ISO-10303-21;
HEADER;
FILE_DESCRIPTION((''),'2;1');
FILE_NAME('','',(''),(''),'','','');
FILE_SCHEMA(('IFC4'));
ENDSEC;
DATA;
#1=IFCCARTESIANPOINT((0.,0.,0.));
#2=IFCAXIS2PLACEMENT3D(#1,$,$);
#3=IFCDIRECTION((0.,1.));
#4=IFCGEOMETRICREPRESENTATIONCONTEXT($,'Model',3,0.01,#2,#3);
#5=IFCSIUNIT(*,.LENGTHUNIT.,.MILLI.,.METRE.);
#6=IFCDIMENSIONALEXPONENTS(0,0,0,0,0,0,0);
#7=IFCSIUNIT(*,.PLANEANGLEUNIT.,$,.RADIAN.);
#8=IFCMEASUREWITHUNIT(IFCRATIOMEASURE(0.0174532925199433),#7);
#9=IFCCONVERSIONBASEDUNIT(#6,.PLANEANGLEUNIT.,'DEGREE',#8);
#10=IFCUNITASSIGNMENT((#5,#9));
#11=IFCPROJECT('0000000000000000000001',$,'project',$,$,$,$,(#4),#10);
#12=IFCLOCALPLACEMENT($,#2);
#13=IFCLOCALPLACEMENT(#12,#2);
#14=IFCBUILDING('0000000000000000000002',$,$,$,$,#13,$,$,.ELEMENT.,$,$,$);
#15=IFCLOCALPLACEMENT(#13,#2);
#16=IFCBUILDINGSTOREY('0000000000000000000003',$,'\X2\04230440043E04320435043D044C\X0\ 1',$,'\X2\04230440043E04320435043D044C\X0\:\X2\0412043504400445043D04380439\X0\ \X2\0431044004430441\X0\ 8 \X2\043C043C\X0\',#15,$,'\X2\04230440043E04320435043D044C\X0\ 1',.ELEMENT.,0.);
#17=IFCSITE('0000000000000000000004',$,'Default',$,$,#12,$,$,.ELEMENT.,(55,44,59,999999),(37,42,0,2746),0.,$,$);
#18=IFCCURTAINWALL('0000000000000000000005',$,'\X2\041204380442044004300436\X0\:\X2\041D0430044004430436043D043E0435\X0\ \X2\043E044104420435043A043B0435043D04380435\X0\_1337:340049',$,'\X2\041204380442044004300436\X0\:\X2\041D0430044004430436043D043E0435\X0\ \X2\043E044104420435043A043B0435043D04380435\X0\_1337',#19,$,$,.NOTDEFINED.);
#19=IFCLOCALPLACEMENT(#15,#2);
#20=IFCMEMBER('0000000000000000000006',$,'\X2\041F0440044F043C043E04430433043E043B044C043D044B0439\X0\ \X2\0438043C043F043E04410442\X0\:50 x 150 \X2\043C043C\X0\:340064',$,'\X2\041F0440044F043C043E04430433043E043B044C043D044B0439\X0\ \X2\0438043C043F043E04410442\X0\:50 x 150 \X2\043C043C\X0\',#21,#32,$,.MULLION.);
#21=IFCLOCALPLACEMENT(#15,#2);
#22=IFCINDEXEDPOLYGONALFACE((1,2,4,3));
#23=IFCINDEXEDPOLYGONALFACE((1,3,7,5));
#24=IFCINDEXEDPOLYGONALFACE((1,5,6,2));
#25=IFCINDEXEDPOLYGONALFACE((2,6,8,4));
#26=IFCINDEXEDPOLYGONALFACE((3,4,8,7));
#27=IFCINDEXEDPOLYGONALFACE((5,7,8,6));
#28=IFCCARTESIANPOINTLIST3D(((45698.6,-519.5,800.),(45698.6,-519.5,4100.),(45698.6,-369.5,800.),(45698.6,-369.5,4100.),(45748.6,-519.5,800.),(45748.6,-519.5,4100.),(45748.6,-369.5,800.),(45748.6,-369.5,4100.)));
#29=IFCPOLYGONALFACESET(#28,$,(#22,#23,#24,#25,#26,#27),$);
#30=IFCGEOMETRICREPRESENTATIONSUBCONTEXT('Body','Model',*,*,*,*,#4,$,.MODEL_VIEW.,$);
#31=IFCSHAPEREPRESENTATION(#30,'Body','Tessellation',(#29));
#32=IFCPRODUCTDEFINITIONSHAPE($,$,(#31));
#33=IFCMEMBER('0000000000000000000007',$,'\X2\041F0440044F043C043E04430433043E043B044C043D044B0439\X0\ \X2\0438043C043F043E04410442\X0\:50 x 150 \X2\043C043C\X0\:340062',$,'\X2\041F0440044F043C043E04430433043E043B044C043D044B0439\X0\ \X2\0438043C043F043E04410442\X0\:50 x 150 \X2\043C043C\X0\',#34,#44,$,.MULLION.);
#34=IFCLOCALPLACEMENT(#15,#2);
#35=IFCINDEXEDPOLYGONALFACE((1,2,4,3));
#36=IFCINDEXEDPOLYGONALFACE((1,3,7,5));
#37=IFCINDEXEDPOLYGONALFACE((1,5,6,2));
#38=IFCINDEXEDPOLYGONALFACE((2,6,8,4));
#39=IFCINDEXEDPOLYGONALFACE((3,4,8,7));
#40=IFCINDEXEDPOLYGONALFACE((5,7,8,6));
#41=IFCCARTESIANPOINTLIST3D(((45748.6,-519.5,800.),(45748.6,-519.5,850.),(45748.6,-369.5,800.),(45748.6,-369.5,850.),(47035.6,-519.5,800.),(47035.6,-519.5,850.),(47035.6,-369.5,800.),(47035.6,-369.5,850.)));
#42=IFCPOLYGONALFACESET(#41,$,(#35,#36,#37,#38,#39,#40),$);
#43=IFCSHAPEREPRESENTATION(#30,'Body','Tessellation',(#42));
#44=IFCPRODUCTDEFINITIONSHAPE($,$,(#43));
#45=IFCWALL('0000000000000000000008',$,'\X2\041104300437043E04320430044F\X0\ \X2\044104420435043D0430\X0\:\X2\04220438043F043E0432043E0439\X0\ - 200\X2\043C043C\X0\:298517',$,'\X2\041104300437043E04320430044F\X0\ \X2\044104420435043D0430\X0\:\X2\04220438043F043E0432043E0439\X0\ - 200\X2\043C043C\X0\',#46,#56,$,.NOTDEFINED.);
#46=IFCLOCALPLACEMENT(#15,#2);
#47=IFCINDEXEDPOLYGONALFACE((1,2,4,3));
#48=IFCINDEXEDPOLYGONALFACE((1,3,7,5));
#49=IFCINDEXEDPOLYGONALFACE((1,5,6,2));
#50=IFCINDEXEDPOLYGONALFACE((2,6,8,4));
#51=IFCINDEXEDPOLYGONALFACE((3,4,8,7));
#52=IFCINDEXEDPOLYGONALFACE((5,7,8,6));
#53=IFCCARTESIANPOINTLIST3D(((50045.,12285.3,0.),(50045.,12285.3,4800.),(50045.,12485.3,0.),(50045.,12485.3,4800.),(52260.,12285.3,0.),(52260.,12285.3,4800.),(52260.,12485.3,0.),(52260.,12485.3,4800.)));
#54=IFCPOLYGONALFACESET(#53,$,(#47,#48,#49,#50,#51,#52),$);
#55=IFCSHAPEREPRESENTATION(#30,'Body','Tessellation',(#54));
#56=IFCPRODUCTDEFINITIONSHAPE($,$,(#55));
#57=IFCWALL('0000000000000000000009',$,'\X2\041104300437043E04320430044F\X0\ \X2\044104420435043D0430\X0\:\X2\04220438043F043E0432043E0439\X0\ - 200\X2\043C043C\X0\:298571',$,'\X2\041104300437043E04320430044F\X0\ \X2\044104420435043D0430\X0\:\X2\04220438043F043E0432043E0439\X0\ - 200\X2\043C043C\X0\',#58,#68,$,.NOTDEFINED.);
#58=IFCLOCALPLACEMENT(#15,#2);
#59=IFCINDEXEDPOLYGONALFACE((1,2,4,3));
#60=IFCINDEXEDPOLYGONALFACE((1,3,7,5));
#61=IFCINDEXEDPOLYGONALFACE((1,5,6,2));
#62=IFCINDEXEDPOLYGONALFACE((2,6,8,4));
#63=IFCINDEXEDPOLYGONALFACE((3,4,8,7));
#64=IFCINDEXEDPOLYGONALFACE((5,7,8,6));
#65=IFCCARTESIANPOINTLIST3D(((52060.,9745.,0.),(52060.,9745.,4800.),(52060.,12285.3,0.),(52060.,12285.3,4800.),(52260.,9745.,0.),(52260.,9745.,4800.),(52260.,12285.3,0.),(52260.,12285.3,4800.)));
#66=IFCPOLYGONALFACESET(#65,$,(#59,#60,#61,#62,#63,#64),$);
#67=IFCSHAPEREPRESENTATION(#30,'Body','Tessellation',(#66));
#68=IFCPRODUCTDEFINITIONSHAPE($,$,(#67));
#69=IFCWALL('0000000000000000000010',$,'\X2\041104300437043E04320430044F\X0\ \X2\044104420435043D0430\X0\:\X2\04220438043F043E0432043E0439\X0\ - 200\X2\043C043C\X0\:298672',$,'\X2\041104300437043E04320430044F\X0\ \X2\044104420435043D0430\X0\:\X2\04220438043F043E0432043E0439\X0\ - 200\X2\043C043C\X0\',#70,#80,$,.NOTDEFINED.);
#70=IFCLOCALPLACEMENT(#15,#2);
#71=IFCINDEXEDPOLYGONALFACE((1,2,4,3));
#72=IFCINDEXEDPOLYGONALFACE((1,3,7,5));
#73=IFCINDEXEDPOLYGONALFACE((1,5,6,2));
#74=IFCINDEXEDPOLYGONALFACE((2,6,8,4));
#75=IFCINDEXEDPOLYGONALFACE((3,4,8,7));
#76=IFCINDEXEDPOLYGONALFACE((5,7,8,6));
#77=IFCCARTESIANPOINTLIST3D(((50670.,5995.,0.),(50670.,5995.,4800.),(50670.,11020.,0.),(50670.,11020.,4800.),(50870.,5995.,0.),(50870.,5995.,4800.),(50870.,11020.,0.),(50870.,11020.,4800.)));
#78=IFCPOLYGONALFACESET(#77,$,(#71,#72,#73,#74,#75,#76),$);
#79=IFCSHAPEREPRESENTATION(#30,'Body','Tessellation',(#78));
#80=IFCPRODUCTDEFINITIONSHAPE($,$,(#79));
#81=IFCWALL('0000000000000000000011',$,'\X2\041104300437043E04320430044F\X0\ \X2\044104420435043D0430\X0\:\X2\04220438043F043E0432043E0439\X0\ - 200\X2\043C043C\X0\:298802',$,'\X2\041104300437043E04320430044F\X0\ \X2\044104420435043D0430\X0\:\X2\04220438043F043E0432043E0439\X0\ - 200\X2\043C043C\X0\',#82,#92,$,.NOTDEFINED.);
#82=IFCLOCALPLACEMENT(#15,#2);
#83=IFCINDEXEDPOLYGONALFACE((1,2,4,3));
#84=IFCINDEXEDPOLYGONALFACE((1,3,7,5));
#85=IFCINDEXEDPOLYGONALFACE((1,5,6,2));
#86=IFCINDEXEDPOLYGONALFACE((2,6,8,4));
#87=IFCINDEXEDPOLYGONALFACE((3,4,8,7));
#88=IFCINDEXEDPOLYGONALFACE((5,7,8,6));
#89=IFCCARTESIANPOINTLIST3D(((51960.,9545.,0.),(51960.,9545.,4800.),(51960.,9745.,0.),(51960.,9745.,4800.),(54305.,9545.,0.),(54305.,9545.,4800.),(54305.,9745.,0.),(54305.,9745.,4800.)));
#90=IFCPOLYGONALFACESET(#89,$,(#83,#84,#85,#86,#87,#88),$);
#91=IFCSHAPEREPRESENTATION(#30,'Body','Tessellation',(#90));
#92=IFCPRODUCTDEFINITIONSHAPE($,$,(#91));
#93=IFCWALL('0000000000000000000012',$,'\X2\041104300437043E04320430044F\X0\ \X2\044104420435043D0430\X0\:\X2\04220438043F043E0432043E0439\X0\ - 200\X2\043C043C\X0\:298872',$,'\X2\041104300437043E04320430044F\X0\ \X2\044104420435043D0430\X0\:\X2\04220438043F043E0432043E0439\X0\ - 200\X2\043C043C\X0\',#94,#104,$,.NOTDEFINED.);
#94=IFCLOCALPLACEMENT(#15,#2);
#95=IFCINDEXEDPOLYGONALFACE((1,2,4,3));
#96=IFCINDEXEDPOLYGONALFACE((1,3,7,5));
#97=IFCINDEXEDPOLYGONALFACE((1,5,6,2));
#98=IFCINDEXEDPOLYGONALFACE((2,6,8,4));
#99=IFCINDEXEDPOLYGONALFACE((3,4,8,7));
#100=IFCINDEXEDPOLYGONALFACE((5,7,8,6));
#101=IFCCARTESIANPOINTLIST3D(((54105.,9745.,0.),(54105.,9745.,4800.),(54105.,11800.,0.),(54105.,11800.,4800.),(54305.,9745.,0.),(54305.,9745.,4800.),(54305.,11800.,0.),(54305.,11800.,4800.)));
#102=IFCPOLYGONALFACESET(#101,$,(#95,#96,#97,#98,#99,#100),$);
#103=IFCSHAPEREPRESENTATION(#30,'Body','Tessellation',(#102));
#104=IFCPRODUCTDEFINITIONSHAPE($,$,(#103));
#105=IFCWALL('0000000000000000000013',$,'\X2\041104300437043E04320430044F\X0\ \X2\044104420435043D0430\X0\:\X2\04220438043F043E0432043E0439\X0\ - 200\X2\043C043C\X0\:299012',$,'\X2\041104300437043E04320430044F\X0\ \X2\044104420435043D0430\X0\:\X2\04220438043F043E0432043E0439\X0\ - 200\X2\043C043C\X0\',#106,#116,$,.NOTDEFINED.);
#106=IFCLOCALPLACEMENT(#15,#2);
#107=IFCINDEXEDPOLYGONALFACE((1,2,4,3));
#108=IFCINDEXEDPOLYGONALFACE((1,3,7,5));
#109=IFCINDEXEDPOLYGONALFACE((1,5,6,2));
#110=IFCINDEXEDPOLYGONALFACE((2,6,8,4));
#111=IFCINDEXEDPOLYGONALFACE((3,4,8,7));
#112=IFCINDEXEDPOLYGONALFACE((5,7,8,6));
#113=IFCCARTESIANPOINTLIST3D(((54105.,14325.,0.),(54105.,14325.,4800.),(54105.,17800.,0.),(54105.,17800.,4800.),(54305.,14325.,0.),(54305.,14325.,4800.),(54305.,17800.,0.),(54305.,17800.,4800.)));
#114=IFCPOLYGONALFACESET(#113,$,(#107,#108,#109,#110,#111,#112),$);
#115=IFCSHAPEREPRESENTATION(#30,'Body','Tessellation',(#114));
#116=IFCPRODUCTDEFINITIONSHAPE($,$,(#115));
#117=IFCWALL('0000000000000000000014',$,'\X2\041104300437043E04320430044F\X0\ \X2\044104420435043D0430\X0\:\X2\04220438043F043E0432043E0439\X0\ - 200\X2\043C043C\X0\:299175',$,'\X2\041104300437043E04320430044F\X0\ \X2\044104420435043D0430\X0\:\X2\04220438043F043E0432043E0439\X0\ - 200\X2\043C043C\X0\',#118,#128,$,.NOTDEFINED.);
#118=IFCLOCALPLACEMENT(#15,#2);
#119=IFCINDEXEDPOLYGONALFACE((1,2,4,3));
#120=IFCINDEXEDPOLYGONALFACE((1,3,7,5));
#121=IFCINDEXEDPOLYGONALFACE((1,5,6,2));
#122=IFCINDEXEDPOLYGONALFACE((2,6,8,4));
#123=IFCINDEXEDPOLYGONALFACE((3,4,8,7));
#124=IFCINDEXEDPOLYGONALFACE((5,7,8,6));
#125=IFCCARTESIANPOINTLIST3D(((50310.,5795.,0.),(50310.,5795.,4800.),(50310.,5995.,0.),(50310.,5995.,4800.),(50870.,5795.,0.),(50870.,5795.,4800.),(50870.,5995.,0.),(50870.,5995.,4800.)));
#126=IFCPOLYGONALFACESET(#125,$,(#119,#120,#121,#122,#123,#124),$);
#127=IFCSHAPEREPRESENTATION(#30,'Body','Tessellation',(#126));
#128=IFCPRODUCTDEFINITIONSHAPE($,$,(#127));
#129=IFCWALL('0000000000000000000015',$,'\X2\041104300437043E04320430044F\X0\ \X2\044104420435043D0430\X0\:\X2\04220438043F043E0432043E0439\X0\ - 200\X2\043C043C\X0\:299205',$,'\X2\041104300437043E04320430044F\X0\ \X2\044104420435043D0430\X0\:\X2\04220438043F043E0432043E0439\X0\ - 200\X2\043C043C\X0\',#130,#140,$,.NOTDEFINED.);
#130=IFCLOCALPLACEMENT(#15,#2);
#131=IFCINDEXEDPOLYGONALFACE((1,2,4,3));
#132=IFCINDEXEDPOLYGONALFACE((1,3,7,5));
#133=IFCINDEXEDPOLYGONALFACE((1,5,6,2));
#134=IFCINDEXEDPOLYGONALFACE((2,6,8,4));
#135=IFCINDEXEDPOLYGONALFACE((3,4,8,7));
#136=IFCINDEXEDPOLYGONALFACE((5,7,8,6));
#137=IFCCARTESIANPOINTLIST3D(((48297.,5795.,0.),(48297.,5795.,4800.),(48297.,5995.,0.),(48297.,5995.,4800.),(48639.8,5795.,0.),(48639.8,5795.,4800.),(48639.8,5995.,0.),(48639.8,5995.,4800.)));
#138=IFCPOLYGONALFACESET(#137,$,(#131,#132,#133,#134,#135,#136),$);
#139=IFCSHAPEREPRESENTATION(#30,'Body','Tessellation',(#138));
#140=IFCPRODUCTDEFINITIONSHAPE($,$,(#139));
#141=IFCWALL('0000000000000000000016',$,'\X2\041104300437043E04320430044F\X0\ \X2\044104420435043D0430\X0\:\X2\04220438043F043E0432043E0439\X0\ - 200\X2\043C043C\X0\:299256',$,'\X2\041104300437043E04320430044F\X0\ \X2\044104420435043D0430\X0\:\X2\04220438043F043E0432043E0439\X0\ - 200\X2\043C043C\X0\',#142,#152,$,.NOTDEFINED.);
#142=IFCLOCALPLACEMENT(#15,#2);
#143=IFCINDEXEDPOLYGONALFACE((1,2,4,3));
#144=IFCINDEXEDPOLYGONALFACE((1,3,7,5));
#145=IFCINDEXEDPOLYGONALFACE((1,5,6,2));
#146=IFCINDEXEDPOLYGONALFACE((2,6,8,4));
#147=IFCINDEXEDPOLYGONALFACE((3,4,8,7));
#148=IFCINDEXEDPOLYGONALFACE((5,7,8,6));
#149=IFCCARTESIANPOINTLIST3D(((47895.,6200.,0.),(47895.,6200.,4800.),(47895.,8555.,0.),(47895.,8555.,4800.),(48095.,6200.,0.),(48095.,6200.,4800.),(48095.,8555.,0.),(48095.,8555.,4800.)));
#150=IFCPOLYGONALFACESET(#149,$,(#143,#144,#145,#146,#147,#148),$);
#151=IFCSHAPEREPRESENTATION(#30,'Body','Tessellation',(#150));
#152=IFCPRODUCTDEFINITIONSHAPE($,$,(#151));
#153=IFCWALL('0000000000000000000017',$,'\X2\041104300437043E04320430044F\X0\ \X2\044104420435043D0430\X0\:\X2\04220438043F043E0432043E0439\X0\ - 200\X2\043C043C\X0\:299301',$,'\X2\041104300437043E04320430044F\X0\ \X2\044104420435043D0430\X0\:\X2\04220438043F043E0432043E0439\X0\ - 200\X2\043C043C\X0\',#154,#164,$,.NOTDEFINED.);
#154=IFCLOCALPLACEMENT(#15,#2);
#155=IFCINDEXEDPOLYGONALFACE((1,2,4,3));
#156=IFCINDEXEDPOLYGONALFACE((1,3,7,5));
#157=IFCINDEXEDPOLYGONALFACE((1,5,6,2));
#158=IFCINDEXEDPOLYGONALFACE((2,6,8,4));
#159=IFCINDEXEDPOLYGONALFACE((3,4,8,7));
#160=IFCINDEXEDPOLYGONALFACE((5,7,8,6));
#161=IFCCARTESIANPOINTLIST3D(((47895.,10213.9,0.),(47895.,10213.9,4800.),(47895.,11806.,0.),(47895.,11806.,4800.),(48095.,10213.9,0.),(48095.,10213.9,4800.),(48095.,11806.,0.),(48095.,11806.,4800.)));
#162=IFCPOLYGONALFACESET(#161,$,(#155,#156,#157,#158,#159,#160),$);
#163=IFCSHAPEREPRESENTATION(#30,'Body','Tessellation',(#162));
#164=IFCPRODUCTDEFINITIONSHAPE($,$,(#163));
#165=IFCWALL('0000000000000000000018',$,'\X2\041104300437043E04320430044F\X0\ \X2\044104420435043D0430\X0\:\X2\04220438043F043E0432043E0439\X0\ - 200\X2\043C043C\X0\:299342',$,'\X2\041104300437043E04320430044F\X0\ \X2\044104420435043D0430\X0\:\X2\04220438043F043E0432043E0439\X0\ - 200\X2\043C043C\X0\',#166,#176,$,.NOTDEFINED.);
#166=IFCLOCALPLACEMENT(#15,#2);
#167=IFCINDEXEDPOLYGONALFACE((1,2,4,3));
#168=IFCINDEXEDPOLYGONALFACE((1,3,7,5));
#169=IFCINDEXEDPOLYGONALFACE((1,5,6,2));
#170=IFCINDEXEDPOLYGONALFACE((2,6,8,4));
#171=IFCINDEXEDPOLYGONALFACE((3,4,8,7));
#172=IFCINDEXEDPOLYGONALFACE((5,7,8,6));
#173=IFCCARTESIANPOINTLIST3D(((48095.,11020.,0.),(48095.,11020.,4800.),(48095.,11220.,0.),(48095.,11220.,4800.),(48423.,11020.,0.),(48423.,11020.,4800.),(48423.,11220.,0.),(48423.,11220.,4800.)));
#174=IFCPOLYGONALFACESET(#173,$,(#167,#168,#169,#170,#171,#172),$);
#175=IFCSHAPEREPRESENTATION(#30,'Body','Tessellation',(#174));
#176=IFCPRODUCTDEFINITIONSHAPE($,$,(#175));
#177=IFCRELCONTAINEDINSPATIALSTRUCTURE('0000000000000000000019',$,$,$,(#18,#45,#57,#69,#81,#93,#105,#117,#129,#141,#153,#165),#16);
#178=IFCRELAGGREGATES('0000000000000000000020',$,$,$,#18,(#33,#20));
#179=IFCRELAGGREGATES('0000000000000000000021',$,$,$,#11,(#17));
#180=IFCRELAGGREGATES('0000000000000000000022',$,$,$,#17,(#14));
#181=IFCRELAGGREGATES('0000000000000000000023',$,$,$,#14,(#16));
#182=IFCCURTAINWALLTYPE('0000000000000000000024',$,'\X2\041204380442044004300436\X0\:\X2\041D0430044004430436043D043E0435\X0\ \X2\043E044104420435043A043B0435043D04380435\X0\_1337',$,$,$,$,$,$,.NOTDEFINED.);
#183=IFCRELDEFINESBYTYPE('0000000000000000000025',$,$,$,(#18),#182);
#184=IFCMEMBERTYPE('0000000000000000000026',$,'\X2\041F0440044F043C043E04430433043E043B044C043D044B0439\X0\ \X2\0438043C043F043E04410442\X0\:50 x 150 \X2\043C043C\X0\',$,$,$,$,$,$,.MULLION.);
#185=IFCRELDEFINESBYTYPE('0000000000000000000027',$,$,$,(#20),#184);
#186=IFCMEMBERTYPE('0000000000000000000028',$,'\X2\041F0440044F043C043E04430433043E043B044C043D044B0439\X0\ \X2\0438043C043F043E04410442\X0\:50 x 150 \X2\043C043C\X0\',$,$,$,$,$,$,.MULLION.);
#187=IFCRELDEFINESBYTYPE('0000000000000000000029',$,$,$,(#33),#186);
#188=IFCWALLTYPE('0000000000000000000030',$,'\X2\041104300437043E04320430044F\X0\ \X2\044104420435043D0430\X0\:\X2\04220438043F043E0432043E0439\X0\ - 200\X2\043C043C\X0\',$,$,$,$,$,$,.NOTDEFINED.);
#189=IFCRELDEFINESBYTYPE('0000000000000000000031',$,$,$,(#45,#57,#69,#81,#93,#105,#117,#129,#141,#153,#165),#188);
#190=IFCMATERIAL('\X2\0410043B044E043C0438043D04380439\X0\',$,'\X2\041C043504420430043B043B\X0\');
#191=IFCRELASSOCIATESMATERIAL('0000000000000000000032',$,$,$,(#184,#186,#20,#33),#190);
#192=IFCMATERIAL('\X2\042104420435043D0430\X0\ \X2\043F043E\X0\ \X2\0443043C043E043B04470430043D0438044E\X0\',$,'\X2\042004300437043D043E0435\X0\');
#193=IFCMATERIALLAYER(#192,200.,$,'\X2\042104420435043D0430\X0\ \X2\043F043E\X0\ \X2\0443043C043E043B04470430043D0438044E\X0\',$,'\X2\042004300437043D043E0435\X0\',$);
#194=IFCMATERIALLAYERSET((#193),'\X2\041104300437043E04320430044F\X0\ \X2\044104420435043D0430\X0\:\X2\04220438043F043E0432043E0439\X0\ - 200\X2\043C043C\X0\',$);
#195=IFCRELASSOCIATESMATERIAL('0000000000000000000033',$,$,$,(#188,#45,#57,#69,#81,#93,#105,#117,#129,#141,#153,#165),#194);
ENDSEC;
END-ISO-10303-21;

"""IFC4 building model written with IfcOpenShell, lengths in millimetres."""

from ifc_helpers import new_model, entity, si_unit, converted_unit, direction, frame, frame_2d, origin, origin_2d_with_axis, place, context, subcontext, project, spatial, rectangle, extrude, source, transform, mapped, material, layer, layer_set, layer_usage, material_profile, profile_set, profile_usage, type_object, type_shapes, element, aggregate, save


model = new_model("IFC4")

# Units and contexts
model_context = context("Model", 3, precision=0.01, world=origin(), true_north=direction((0.0, 1.0)))
body_context = subcontext(model_context, "Body", "Model", "MODEL_VIEW")
ifc_project = project(units=[si_unit("LENGTHUNIT", "METRE", prefix="MILLI"), converted_unit("PLANEANGLEUNIT", "DEGREE", entity("IfcRatioMeasure", 0.0174532925199433), si_unit("PLANEANGLEUNIT", "RADIAN"), dimensions=[0, 0, 0, 0, 0, 0, 0])], contexts=[model_context])

# Site, building, storey
site_placement = place(None, origin())
site = spatial("IfcSite", under=ifc_project, at=site_placement, Name="Default", CompositionType="ELEMENT", RefLatitude=(55, 44, 59, 999999), RefLongitude=(37, 42, 0, 2746), RefElevation=0.0)
building_placement = place(site_placement, origin())
building = spatial("IfcBuilding", under=site, at=building_placement, CompositionType="ELEMENT")
storey_placement = place(building_placement, origin())
storey = spatial("IfcBuildingStorey", under=building, at=storey_placement, Name="Уровень 1", ObjectType="Уровень:Верхний брус 8 мм", LongName="Уровень 1", CompositionType="ELEMENT", Elevation=0.0)

# Curtain wall, members
curtain_wall_type_1 = type_object("IfcCurtainWallType", Name="Витраж:Наружное остекление_1337", PredefinedType="NOTDEFINED")
curtain_wall_1_placement = place(storey_placement, origin())
curtain_wall_1 = element("IfcCurtainWall", 1, at=curtain_wall_1_placement, inside=storey, type_object=curtain_wall_type_1, Name="Витраж:Наружное остекление_1337:340049", ObjectType="Витраж:Наружное остекление_1337", PredefinedType="NOTDEFINED")
ifc_material_1 = material(Name="Алюминий", Category="Металл")
ifc_material_profile = material_profile(ifc_material_1, rectangle(XDim=150.0, YDim=50.0, at=origin_2d_with_axis()), Name="50 x 150 мм")
ifc_profile_set = profile_set([ifc_material_profile], Name="50 x 150 мм")
ifc_profile_usage_1 = profile_usage(ifc_profile_set)
member_type_1 = type_object("IfcMemberType", Name="Прямоугольный импост:50 x 150 мм", PredefinedType="MULLION", material=ifc_profile_set)
shared_shape_1 = source(origin(), body_context, "Body", "SweptSolid", [
    extrude(rectangle(XDim=150.0, YDim=50.0, at=origin_2d_with_axis()), frame((0.0, 0.0, -3300.0), z_axis=(0.0, 0.0, 1.0), x_axis=(0.0, -1.0, 0.0)), (0.0, 0.0, 1.0), 3300.0),
])
type_shapes(member_type_1, [shared_shape_1])
member_1_placement = place(storey_placement, frame((45723.6, -444.5, 800.0), z_axis=(0.0, 0.0, -1.0), x_axis=(1.0, 0.0, 0.0)))
member_1 = element("IfcMember", 2, at=member_1_placement, type_object=member_type_1, material=ifc_profile_usage_1, Name="Прямоугольный импост:50 x 150 мм:340064", ObjectType="Прямоугольный импост:50 x 150 мм", PredefinedType="MULLION", context=body_context, shape_type="MappedRepresentation", body=[
    mapped(shared_shape_1, transform((0.0, 0.0, 0.0), scale=1.0)),
])
ifc_profile_usage_2 = profile_usage(ifc_profile_set)
member_type_2 = type_object("IfcMemberType", Name="Прямоугольный импост:50 x 150 мм", PredefinedType="MULLION", material=ifc_profile_set)
shared_shape_2 = source(origin(), body_context, "Body", "SweptSolid", [
    extrude(rectangle(XDim=150.0, YDim=50.0, at=origin_2d_with_axis()), frame((-25.0, 0.0, -1287.0), z_axis=(0.0, 0.0, 1.0), x_axis=(0.0, -1.0, 0.0)), (0.0, 0.0, 1.0), 1287.0),
])
type_shapes(member_type_2, [shared_shape_2])
member_2_placement = place(storey_placement, frame((45748.6, -444.5, 800.0), z_axis=(-1.0, 0.0, 0.0), x_axis=(0.0, 0.0, -1.0)))
member_2 = element("IfcMember", 3, at=member_2_placement, type_object=member_type_2, material=ifc_profile_usage_2, Name="Прямоугольный импост:50 x 150 мм:340062", ObjectType="Прямоугольный импост:50 x 150 мм", PredefinedType="MULLION", context=body_context, shape_type="MappedRepresentation", body=[
    mapped(shared_shape_2, transform((0.0, 0.0, 0.0), scale=1.0)),
])

aggregate(curtain_wall_1, [member_2, member_1])

# Walls
ifc_material_2 = material(Name="Стена по умолчанию", Category="Разное")
ifc_layer = layer(ifc_material_2, 200.0, Name="Стена по умолчанию", Category="Разное")
ifc_layer_set = layer_set([ifc_layer], Name="Базовая стена:Типовой - 200мм")
ifc_layer_usage_1 = layer_usage(ifc_layer_set, "AXIS2", "NEGATIVE", 100.0)
wall_type = type_object("IfcWallType", Name="Базовая стена:Типовой - 200мм", PredefinedType="NOTDEFINED", material=ifc_layer_set)
wall_1_placement = place(storey_placement, frame((50045.0, 12385.3, 0.0)))
element("IfcWall", 4, at=wall_1_placement, inside=storey, type_object=wall_type, material=ifc_layer_usage_1, Name="Базовая стена:Типовой - 200мм:298517", ObjectType="Базовая стена:Типовой - 200мм", PredefinedType="NOTDEFINED", context=body_context, shape_type="SweptSolid", body=[
    extrude(rectangle(XDim=2215.0, YDim=200.0, at=frame_2d((1107.5, 0.0), x_axis=(-1.0, 0.0))), origin(), (0.0, 0.0, 1.0), 4800.0),
])
ifc_layer_usage_2 = layer_usage(ifc_layer_set, "AXIS2", "NEGATIVE", 100.0)
wall_2_placement = place(storey_placement, frame((52160.0, 12285.3, 0.0), z_axis=(0.0, 0.0, 1.0), x_axis=(0.0, -1.0, 0.0)))
element("IfcWall", 5, at=wall_2_placement, inside=storey, type_object=wall_type, material=ifc_layer_usage_2, Name="Базовая стена:Типовой - 200мм:298571", ObjectType="Базовая стена:Типовой - 200мм", PredefinedType="NOTDEFINED", context=body_context, shape_type="SweptSolid", body=[
    extrude(rectangle(XDim=2540.3, YDim=200.0, at=frame_2d((1270.1, 0.0), x_axis=(-1.0, 0.0))), origin(), (0.0, 0.0, 1.0), 4800.0),
])

# Wall
ifc_layer_usage_3 = layer_usage(ifc_layer_set, "AXIS2", "NEGATIVE", 100.0)
wall_3_placement = place(storey_placement, frame((50770.0, 11020.0, 0.0), z_axis=(0.0, 0.0, 1.0), x_axis=(0.0, -1.0, 0.0)))
element("IfcWall", 6, at=wall_3_placement, inside=storey, type_object=wall_type, material=ifc_layer_usage_3, Name="Базовая стена:Типовой - 200мм:298672", ObjectType="Базовая стена:Типовой - 200мм", PredefinedType="NOTDEFINED", context=body_context, shape_type="SweptSolid", body=[
    extrude(rectangle(XDim=5025.0, YDim=200.0, at=frame_2d((2512.5, 0.0), x_axis=(-1.0, 0.0))), origin(), (0.0, 0.0, 1.0), 4800.0),
])

# Walls
ifc_layer_usage_4 = layer_usage(ifc_layer_set, "AXIS2", "NEGATIVE", 100.0)
wall_4_placement = place(storey_placement, frame((51960.0, 9645.0, 0.0)))
element("IfcWall", 7, at=wall_4_placement, inside=storey, type_object=wall_type, material=ifc_layer_usage_4, Name="Базовая стена:Типовой - 200мм:298802", ObjectType="Базовая стена:Типовой - 200мм", PredefinedType="NOTDEFINED", context=body_context, shape_type="SweptSolid", body=[
    extrude(rectangle(XDim=2345.0, YDim=200.0, at=frame_2d((1172.5, 0.0), x_axis=(-1.0, 0.0))), origin(), (0.0, 0.0, 1.0), 4800.0),
])
ifc_layer_usage_5 = layer_usage(ifc_layer_set, "AXIS2", "NEGATIVE", 100.0)
wall_5_placement = place(storey_placement, frame((54205.0, 9745.0, 0.0), z_axis=(0.0, 0.0, 1.0), x_axis=(0.0, 1.0, 0.0)))
element("IfcWall", 8, at=wall_5_placement, inside=storey, type_object=wall_type, material=ifc_layer_usage_5, Name="Базовая стена:Типовой - 200мм:298872", ObjectType="Базовая стена:Типовой - 200мм", PredefinedType="NOTDEFINED", context=body_context, shape_type="SweptSolid", body=[
    extrude(rectangle(XDim=2055.0, YDim=200.0, at=frame_2d((1027.5, 0.0), x_axis=(-1.0, 0.0))), origin(), (0.0, 0.0, 1.0), 4800.0),
])

# Walls
ifc_layer_usage_6 = layer_usage(ifc_layer_set, "AXIS2", "NEGATIVE", 100.0)
wall_6_placement = place(storey_placement, frame((54205.0, 14325.0, 0.0), z_axis=(0.0, 0.0, 1.0), x_axis=(0.0, 1.0, 0.0)))
element("IfcWall", 9, at=wall_6_placement, inside=storey, type_object=wall_type, material=ifc_layer_usage_6, Name="Базовая стена:Типовой - 200мм:299012", ObjectType="Базовая стена:Типовой - 200мм", PredefinedType="NOTDEFINED", context=body_context, shape_type="SweptSolid", body=[
    extrude(rectangle(XDim=3475.0, YDim=200.0, at=frame_2d((1737.5, 0.0), x_axis=(-1.0, 0.0))), origin(), (0.0, 0.0, 1.0), 4800.0),
])
ifc_layer_usage_7 = layer_usage(ifc_layer_set, "AXIS2", "NEGATIVE", 100.0)
wall_7_placement = place(storey_placement, frame((50870.0, 5895.0, 0.0), z_axis=(0.0, 0.0, 1.0), x_axis=(-1.0, 0.0, 0.0)))
element("IfcWall", 10, at=wall_7_placement, inside=storey, type_object=wall_type, material=ifc_layer_usage_7, Name="Базовая стена:Типовой - 200мм:299175", ObjectType="Базовая стена:Типовой - 200мм", PredefinedType="NOTDEFINED", context=body_context, shape_type="SweptSolid", body=[
    extrude(rectangle(XDim=560.0, YDim=200.0, at=frame_2d((280.0, 0.0), x_axis=(-1.0, 0.0))), origin(), (0.0, 0.0, 1.0), 4800.0),
])
ifc_layer_usage_8 = layer_usage(ifc_layer_set, "AXIS2", "NEGATIVE", 100.0)
wall_8_placement = place(storey_placement, frame((48639.8, 5895.0, 0.0), z_axis=(0.0, 0.0, 1.0), x_axis=(-1.0, 0.0, 0.0)))
element("IfcWall", 11, at=wall_8_placement, inside=storey, type_object=wall_type, material=ifc_layer_usage_8, Name="Базовая стена:Типовой - 200мм:299205", ObjectType="Базовая стена:Типовой - 200мм", PredefinedType="NOTDEFINED", context=body_context, shape_type="SweptSolid", body=[
    extrude(rectangle(XDim=342.7, YDim=200.0, at=frame_2d((171.4, 0.0), x_axis=(-1.0, 0.0))), origin(), (0.0, 0.0, 1.0), 4800.0),
])
ifc_layer_usage_9 = layer_usage(ifc_layer_set, "AXIS2", "NEGATIVE", 100.0)
wall_9_placement = place(storey_placement, frame((47995.0, 6200.0, 0.0), z_axis=(0.0, 0.0, 1.0), x_axis=(0.0, 1.0, 0.0)))
element("IfcWall", 12, at=wall_9_placement, inside=storey, type_object=wall_type, material=ifc_layer_usage_9, Name="Базовая стена:Типовой - 200мм:299256", ObjectType="Базовая стена:Типовой - 200мм", PredefinedType="NOTDEFINED", context=body_context, shape_type="SweptSolid", body=[
    extrude(rectangle(XDim=2355.0, YDim=200.0, at=frame_2d((1177.5, 0.0), x_axis=(-1.0, 0.0))), origin(), (0.0, 0.0, 1.0), 4800.0),
])
ifc_layer_usage_10 = layer_usage(ifc_layer_set, "AXIS2", "NEGATIVE", 100.0)
wall_10_placement = place(storey_placement, frame((47995.0, 10213.9, 0.0), z_axis=(0.0, 0.0, 1.0), x_axis=(0.0, 1.0, 0.0)))
element("IfcWall", 13, at=wall_10_placement, inside=storey, type_object=wall_type, material=ifc_layer_usage_10, Name="Базовая стена:Типовой - 200мм:299301", ObjectType="Базовая стена:Типовой - 200мм", PredefinedType="NOTDEFINED", context=body_context, shape_type="SweptSolid", body=[
    extrude(rectangle(XDim=1592.1, YDim=200.0, at=frame_2d((796.0, 0.0), x_axis=(-1.0, 0.0))), origin(), (0.0, 0.0, 1.0), 4800.0),
])
ifc_layer_usage_11 = layer_usage(ifc_layer_set, "AXIS2", "NEGATIVE", 100.0)
wall_11_placement = place(storey_placement, frame((48095.0, 11120.0, 0.0)))
element("IfcWall", 14, at=wall_11_placement, inside=storey, type_object=wall_type, material=ifc_layer_usage_11, Name="Базовая стена:Типовой - 200мм:299342", ObjectType="Базовая стена:Типовой - 200мм", PredefinedType="NOTDEFINED", context=body_context, shape_type="SweptSolid", body=[
    extrude(rectangle(XDim=328.0, YDim=200.0, at=frame_2d((164.0, 0.0), x_axis=(-1.0, 0.0))), origin(), (0.0, 0.0, 1.0), 4800.0),
])

save(model, "model.ifc")
